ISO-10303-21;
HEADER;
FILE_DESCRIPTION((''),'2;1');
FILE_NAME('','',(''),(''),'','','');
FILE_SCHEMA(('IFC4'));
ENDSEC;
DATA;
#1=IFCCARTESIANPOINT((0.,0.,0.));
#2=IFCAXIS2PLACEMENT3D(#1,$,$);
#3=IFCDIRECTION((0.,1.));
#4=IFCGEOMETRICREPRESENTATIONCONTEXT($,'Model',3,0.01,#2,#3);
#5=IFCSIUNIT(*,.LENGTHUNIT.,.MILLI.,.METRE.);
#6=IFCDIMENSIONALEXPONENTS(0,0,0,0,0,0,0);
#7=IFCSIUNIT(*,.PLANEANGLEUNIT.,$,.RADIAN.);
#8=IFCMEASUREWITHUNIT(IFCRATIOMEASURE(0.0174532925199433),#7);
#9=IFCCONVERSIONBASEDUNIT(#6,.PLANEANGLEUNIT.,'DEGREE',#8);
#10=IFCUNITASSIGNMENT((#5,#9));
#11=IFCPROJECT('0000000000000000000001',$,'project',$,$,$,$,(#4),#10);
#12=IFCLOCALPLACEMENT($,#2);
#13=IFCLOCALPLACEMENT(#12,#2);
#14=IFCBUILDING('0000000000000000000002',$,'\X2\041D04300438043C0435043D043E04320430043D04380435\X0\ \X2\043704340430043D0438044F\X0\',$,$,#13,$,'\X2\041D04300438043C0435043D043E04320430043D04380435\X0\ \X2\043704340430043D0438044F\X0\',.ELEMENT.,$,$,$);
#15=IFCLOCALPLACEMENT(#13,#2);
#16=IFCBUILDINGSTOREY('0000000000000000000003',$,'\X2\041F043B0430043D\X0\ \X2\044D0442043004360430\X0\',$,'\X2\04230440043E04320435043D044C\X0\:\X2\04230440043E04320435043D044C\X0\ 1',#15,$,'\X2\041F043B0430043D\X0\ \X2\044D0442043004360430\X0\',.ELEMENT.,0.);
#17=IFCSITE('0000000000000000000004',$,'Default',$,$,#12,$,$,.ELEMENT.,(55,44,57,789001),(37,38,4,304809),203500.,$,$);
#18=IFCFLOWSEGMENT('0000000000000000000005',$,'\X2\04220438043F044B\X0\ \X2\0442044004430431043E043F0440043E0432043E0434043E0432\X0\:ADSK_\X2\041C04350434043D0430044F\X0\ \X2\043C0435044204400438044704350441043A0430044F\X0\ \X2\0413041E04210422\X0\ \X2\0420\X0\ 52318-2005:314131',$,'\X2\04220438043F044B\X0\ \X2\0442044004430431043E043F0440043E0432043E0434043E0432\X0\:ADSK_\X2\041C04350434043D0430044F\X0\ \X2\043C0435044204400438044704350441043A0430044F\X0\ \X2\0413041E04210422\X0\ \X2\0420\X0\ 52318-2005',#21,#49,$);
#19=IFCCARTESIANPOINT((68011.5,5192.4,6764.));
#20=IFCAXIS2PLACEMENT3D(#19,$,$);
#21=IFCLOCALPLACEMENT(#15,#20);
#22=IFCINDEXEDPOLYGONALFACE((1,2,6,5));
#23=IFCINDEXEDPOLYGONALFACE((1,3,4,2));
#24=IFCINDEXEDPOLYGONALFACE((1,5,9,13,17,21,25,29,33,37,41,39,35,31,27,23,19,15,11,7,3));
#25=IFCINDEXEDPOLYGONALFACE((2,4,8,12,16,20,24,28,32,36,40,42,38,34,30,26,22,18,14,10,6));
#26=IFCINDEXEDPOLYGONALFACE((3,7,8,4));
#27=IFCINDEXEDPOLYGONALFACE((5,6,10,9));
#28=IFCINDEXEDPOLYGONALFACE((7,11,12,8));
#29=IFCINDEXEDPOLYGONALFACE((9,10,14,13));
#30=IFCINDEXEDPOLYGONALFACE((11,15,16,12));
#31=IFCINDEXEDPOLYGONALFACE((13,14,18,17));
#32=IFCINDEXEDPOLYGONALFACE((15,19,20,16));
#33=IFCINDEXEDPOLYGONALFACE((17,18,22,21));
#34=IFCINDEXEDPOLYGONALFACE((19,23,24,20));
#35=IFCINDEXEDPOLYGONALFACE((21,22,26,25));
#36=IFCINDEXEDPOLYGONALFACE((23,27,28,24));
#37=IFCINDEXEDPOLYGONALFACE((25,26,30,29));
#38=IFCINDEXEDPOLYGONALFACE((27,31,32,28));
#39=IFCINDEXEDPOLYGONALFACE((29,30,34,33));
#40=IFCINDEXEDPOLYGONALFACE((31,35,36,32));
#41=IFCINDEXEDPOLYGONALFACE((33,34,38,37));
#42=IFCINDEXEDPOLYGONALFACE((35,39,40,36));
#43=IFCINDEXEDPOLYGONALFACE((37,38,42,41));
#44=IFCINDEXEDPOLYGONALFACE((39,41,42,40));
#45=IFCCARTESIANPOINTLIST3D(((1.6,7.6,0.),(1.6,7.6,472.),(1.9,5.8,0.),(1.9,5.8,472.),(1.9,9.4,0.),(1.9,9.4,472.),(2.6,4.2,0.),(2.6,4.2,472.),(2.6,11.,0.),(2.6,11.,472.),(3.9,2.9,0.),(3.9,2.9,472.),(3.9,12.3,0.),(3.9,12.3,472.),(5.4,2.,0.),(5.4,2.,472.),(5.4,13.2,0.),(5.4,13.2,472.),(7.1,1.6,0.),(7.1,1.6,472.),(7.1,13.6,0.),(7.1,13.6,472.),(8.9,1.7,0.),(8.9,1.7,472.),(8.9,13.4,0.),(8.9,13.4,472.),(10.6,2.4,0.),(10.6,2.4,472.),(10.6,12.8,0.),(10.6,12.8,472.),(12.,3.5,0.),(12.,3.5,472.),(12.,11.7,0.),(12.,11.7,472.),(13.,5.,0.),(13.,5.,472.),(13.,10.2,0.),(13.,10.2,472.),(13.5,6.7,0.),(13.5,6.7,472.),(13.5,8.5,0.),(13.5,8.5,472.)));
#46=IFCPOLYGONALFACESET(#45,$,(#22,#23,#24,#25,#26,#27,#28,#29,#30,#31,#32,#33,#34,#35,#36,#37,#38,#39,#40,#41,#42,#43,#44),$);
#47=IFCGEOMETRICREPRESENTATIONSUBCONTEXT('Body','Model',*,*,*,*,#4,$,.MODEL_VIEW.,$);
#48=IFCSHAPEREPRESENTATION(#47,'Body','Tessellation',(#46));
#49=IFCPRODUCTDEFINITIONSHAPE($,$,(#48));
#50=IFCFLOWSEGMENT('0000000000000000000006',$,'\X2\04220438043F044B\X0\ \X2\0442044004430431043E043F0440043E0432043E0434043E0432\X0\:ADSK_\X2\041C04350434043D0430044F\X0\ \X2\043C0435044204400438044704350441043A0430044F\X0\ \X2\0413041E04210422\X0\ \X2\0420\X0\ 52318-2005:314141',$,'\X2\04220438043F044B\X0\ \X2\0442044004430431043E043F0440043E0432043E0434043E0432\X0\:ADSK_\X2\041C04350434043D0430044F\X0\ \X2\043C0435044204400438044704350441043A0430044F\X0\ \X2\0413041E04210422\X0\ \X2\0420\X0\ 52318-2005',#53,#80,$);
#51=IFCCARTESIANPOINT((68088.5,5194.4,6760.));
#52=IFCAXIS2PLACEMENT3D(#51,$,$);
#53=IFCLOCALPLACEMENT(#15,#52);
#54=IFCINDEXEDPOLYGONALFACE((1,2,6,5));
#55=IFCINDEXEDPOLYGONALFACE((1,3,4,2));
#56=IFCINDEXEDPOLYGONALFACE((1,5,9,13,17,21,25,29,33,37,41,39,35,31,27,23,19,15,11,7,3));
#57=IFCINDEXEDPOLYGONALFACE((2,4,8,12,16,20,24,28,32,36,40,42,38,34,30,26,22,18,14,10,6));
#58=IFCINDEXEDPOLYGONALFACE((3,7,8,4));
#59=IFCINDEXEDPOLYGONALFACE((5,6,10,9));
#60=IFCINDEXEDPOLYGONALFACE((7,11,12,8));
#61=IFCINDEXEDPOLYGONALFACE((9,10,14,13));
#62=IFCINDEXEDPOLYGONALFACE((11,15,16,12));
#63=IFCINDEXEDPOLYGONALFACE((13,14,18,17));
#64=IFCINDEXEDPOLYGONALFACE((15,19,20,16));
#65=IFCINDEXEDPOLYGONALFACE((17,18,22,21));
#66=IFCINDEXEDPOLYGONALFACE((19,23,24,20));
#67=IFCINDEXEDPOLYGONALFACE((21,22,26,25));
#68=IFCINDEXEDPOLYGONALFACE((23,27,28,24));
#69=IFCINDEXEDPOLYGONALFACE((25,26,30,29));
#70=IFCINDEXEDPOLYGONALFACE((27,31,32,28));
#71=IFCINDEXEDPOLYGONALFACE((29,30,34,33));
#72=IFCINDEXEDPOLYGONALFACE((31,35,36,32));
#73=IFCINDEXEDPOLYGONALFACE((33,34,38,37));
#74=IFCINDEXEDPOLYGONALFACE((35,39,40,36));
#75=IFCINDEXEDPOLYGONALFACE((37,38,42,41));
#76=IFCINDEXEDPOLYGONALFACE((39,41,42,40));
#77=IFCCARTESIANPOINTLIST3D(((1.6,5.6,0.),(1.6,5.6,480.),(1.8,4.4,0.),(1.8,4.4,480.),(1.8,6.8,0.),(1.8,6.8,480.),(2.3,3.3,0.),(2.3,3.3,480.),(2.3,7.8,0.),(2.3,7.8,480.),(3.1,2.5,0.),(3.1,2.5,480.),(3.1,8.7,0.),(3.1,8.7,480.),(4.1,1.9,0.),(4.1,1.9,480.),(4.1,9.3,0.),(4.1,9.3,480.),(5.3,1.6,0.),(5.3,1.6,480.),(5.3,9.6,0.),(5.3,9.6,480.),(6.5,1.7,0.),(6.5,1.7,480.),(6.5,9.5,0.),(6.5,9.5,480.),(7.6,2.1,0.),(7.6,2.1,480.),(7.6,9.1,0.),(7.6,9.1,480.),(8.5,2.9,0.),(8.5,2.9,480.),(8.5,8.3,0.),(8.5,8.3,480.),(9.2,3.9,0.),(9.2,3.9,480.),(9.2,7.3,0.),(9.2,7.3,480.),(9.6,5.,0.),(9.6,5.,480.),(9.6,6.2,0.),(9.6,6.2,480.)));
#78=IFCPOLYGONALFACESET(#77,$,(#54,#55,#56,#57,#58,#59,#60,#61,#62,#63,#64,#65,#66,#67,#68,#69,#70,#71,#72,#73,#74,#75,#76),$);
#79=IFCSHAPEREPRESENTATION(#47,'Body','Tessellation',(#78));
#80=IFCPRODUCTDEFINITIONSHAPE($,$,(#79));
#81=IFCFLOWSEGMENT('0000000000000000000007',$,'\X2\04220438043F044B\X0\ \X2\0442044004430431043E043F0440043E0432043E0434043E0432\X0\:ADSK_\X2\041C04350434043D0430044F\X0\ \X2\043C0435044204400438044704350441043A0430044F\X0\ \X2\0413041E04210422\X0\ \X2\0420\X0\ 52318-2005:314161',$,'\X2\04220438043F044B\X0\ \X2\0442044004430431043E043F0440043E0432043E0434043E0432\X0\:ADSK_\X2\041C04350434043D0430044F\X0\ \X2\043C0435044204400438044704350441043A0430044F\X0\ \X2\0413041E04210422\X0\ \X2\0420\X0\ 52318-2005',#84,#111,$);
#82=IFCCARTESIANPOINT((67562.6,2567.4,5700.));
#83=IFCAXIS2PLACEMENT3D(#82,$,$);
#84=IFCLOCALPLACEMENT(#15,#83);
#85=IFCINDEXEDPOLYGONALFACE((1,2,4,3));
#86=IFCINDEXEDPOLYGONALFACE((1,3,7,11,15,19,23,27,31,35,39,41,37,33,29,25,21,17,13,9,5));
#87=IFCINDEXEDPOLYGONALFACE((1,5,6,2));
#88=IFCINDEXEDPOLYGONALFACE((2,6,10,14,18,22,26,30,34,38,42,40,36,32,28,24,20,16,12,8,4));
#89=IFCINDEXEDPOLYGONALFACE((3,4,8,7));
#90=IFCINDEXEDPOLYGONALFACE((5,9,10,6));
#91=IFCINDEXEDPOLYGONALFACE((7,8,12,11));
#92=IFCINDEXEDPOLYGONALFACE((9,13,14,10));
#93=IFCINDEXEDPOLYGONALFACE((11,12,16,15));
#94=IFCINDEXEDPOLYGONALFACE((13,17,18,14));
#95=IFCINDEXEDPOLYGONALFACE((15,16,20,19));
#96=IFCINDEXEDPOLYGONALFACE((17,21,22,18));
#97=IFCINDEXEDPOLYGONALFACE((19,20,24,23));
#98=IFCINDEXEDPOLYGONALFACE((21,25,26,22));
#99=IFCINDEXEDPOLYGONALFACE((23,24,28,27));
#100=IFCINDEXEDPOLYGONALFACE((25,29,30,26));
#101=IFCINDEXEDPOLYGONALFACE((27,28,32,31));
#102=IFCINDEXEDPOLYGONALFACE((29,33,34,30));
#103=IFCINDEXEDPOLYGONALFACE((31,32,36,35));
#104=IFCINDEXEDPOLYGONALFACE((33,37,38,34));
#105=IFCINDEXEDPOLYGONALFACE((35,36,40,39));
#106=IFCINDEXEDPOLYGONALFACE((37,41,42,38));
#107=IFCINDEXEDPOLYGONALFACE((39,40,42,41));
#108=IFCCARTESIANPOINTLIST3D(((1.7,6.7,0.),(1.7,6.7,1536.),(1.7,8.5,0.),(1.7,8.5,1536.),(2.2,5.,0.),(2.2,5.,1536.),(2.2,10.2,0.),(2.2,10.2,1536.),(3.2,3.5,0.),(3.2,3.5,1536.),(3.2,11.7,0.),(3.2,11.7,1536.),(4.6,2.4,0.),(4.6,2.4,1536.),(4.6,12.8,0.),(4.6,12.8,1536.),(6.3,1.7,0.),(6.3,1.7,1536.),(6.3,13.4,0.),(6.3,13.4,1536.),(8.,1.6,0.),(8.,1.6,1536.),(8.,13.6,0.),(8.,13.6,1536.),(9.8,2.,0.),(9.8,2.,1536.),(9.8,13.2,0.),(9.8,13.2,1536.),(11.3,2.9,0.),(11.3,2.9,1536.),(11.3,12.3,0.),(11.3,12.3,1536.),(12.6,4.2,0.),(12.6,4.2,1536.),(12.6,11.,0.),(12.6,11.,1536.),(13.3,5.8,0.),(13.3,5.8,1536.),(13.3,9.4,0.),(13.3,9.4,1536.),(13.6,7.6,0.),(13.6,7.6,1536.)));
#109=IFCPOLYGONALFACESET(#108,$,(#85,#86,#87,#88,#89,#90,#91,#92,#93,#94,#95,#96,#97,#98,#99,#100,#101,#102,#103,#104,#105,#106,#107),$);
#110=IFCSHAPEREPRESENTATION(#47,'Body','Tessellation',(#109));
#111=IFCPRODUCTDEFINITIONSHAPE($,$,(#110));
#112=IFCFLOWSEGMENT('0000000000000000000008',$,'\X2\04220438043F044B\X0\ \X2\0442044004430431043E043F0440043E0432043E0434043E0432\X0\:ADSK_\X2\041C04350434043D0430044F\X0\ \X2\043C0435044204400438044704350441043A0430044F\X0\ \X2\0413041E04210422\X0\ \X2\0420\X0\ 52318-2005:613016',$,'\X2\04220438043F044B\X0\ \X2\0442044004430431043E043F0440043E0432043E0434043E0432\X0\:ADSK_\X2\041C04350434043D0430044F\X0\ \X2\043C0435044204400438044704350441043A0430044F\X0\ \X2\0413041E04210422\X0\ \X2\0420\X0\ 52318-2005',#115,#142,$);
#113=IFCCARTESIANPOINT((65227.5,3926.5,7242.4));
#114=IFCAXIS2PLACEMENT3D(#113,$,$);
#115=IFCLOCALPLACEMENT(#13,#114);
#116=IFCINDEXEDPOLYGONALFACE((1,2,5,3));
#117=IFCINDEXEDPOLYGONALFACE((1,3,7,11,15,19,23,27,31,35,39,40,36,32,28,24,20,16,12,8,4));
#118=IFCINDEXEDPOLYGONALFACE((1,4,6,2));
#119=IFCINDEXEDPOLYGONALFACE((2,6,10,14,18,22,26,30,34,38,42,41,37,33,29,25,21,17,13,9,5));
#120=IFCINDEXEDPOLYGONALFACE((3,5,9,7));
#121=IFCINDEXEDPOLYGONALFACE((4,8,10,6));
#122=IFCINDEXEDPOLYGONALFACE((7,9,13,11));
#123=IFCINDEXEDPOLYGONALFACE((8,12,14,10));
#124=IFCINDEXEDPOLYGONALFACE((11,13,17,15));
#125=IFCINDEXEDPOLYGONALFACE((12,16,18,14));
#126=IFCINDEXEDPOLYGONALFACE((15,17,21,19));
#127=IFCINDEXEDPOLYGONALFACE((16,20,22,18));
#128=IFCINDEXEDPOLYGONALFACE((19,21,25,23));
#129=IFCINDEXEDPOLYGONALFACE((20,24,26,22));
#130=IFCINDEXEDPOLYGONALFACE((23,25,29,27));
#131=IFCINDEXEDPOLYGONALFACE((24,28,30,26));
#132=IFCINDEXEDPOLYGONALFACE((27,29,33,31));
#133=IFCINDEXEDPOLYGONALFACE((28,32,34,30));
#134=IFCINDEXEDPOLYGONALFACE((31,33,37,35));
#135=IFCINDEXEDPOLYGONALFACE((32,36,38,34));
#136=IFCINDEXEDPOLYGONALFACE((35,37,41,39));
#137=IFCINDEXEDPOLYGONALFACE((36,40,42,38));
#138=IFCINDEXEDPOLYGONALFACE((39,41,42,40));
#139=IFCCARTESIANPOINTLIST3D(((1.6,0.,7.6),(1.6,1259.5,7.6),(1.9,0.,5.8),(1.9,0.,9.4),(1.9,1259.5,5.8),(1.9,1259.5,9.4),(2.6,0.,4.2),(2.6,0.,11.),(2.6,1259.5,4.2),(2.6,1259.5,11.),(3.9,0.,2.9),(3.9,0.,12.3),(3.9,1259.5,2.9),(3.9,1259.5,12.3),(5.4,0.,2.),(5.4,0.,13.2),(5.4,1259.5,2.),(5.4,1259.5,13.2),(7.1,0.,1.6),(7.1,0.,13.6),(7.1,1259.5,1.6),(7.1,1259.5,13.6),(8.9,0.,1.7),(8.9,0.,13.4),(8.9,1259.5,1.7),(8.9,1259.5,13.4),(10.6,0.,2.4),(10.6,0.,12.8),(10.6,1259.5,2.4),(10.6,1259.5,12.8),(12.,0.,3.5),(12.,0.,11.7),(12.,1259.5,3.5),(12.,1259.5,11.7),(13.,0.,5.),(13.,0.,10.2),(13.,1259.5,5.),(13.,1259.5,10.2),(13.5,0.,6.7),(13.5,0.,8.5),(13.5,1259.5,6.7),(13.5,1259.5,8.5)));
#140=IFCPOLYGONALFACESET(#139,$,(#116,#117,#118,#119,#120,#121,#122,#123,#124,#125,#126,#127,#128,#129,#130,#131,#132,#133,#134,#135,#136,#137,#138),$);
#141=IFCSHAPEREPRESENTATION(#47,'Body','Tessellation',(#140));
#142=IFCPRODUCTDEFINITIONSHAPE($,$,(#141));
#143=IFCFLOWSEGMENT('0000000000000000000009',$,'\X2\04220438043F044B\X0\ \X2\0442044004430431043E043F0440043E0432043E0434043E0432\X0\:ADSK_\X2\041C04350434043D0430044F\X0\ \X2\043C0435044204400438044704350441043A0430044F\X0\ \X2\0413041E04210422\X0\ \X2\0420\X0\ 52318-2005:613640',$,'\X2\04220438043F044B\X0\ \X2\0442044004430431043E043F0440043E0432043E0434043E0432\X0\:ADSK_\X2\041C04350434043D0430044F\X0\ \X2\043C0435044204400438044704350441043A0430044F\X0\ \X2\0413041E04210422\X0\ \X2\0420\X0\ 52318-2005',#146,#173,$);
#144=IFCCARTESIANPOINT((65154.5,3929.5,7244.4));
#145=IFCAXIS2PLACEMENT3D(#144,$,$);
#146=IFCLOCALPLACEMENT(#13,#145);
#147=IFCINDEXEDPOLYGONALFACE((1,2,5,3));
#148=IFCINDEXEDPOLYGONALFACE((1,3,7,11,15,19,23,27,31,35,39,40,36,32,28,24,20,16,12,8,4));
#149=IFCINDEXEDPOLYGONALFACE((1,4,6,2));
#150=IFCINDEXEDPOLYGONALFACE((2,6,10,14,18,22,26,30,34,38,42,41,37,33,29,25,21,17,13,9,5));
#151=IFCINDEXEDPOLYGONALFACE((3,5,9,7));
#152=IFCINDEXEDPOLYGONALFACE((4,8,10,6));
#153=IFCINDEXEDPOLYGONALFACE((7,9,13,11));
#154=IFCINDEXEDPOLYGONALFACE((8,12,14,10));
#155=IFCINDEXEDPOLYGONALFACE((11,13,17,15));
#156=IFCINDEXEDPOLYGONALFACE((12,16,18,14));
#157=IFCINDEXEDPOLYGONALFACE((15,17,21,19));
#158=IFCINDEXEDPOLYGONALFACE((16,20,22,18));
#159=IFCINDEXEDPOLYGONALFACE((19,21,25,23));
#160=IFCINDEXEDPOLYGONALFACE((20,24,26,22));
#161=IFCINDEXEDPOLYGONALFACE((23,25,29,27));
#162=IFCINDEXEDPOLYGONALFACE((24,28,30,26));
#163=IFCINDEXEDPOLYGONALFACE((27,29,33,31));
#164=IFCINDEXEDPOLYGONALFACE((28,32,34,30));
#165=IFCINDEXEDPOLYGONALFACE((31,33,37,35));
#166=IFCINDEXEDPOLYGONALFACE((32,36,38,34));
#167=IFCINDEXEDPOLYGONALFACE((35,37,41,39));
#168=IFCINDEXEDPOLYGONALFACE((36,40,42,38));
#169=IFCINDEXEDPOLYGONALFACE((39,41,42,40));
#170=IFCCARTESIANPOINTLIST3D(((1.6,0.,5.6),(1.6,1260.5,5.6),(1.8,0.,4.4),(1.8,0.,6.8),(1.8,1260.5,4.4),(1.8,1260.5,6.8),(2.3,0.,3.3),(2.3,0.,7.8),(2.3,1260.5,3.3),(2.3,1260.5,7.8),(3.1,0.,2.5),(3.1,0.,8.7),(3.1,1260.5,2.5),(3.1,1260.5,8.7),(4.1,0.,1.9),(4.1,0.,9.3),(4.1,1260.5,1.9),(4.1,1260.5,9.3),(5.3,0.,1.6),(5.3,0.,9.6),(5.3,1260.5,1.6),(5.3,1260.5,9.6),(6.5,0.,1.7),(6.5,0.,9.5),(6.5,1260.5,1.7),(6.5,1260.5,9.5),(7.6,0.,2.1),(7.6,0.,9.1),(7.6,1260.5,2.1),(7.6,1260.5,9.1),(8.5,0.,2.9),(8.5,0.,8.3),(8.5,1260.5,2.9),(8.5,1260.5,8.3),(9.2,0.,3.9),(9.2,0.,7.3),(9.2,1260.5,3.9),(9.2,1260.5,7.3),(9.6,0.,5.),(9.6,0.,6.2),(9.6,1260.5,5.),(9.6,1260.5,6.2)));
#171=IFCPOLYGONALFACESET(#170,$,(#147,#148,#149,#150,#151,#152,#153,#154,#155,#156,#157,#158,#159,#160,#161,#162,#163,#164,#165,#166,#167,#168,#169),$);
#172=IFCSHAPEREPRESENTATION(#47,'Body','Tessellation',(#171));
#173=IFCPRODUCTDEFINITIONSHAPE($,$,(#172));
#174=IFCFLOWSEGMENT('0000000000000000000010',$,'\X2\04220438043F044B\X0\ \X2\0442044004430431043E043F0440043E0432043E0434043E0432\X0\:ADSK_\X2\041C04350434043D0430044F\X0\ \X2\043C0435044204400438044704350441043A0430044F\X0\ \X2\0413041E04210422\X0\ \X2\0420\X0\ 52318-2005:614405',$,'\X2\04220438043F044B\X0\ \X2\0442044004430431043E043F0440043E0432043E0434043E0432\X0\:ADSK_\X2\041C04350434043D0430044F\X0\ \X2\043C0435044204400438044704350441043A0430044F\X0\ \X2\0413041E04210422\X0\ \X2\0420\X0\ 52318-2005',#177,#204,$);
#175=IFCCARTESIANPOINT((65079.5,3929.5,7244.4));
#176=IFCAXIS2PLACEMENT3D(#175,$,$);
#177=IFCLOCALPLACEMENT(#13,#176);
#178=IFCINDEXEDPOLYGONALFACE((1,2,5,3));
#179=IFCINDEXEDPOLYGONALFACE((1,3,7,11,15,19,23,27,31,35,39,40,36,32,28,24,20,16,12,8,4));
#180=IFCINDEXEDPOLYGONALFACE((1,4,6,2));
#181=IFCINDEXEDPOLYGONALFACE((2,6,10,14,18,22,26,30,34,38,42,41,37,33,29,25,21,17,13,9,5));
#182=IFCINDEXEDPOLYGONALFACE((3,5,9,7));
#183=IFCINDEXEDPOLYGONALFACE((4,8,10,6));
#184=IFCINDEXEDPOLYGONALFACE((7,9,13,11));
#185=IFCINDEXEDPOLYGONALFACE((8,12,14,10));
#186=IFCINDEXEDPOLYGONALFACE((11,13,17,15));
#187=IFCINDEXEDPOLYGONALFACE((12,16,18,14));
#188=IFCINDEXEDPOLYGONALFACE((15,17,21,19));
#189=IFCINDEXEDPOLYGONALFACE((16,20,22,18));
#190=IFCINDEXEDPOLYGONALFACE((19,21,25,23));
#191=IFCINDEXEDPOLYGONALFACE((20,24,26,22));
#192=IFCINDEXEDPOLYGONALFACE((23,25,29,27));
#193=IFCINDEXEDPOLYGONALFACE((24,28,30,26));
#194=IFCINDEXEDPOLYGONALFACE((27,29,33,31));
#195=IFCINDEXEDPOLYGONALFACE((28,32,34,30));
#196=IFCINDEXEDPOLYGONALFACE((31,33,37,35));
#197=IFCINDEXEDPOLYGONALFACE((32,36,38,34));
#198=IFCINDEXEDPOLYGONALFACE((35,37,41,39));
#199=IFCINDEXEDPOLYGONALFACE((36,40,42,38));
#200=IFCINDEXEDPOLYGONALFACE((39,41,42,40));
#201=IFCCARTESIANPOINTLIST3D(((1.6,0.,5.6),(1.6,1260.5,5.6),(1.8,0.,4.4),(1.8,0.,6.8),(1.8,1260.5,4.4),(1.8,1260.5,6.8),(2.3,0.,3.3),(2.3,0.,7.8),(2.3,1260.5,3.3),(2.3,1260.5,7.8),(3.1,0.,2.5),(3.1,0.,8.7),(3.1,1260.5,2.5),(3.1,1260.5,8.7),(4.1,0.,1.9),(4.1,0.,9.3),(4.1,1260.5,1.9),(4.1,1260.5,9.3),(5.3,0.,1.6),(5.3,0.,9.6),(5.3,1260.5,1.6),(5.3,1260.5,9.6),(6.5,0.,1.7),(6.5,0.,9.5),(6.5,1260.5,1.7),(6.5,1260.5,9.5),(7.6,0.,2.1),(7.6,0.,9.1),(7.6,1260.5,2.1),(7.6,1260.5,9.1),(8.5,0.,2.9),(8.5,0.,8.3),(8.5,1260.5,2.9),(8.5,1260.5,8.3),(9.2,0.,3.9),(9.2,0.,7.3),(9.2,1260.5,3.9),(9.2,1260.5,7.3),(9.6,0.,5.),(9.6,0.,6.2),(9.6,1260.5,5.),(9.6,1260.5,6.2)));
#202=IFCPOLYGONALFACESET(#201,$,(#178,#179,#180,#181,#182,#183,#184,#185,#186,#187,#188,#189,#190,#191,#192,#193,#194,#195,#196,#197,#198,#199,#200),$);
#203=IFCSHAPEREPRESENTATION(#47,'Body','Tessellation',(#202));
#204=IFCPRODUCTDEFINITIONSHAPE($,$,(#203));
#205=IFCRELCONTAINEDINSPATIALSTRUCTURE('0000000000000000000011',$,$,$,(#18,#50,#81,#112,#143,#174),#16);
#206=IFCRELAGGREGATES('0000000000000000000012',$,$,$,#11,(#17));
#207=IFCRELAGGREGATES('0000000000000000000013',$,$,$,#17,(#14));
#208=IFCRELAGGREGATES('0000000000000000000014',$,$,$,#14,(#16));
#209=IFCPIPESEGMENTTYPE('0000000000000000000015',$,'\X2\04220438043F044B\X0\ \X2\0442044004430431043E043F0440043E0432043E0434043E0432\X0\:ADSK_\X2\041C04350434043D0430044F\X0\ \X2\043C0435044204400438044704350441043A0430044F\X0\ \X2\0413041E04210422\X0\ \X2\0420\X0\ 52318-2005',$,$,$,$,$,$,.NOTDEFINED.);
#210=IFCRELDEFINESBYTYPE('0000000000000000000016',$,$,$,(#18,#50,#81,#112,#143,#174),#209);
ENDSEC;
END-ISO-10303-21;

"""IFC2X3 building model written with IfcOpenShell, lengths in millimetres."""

from ifc_helpers import new_model, entity, si_unit, converted_unit, direction, frame, frame_2d, origin, origin_2d_with_axis, place, context, subcontext, project, spatial, circle, extrude, type_object, element, save


model = new_model("IFC2X3")

# Units and contexts
model_context = context("Model", 3, precision=0.01, world=origin(), true_north=direction((0.0, 1.0)))
body_context = subcontext(model_context, "Body", "Model", "MODEL_VIEW")
ifc_project = project(units=[si_unit("LENGTHUNIT", "METRE", prefix="MILLI"), converted_unit("PLANEANGLEUNIT", "DEGREE", entity("IfcRatioMeasure", 0.0174532925199433), si_unit("PLANEANGLEUNIT", "RADIAN"), dimensions=[0, 0, 0, 0, 0, 0, 0])], contexts=[model_context])

# Site, building, storey
site_placement = place(None, frame((0.0, 0.0, 0.0)))
site = spatial("IfcSite", under=ifc_project, at=site_placement, Name="Default", CompositionType="ELEMENT", RefLatitude=(55, 44, 57, 789001), RefLongitude=(37, 38, 4, 304809), RefElevation=203500.0)
building_placement = place(site_placement, origin())
building = spatial("IfcBuilding", under=site, at=building_placement, Name="Наименование здания", LongName="Наименование здания", CompositionType="ELEMENT")
storey_placement = place(building_placement, origin())
storey = spatial("IfcBuildingStorey", under=building, at=storey_placement, Name="План этажа", ObjectType="Уровень:Уровень 1", LongName="План этажа", CompositionType="ELEMENT", Elevation=0.0)

# Flow segments
pipe_segment_type = type_object("IfcPipeSegmentType", Name="Типы трубопроводов:ADSK_Медная метрическая ГОСТ Р 52318-2005", PredefinedType="NOTDEFINED")
flow_segment_1_placement = place(storey_placement, frame((68011.5, 5192.4, 6764.0)))
element("IfcFlowSegment", 1, at=flow_segment_1_placement, inside=storey, type_object=pipe_segment_type, Name="Типы трубопроводов:ADSK_Медная метрическая ГОСТ Р 52318-2005:314131", ObjectType="Типы трубопроводов:ADSK_Медная метрическая ГОСТ Р 52318-2005", context=body_context, shape_type="SweptSolid", body=[
    extrude(circle(Radius=6.0, at=origin_2d_with_axis()), frame((7.6, 7.6, 0.0), z_axis=(0.0, 0.0, 1.0), x_axis=(-1.0, 0.0, 0.0)), (0.0, 0.0, 1.0), 472.0),
])
flow_segment_2_placement = place(storey_placement, frame((68088.5, 5194.4, 6760.0)))
element("IfcFlowSegment", 2, at=flow_segment_2_placement, inside=storey, type_object=pipe_segment_type, Name="Типы трубопроводов:ADSK_Медная метрическая ГОСТ Р 52318-2005:314141", ObjectType="Типы трубопроводов:ADSK_Медная метрическая ГОСТ Р 52318-2005", context=body_context, shape_type="SweptSolid", body=[
    extrude(circle(Radius=4.0, at=origin_2d_with_axis()), frame((5.6, 5.6, 0.0), z_axis=(0.0, 0.0, 1.0), x_axis=(-1.0, 0.0, 0.0)), (0.0, 0.0, 1.0), 480.0),
])
flow_segment_3_placement = place(storey_placement, frame((67562.6, 2567.4, 5700.0)))
element("IfcFlowSegment", 3, at=flow_segment_3_placement, inside=storey, type_object=pipe_segment_type, Name="Типы трубопроводов:ADSK_Медная метрическая ГОСТ Р 52318-2005:314161", ObjectType="Типы трубопроводов:ADSK_Медная метрическая ГОСТ Р 52318-2005", context=body_context, shape_type="SweptSolid", body=[
    extrude(circle(Radius=6.0, at=origin_2d_with_axis()), frame((7.6, 7.6, 0.0)), (0.0, 0.0, 1.0), 1536.0),
])
flow_segment_4_placement = place(building_placement, frame((65227.5, 3926.5, 7242.4)))
element("IfcFlowSegment", 4, at=flow_segment_4_placement, inside=storey, type_object=pipe_segment_type, Name="Типы трубопроводов:ADSK_Медная метрическая ГОСТ Р 52318-2005:613016", ObjectType="Типы трубопроводов:ADSK_Медная метрическая ГОСТ Р 52318-2005", context=body_context, shape_type="SweptSolid", body=[
    extrude(circle(Radius=6.0, at=frame_2d((0.0, 0.0), x_axis=(1.0, 0.0))), frame((7.6, 0.0, 7.6), z_axis=(0.0, 1.0, 0.0), x_axis=(-1.0, 0.0, 0.0)), (0.0, 0.0, 1.0), 1259.5),
])
flow_segment_5_placement = place(building_placement, frame((65154.5, 3929.5, 7244.4)))
element("IfcFlowSegment", 5, at=flow_segment_5_placement, inside=storey, type_object=pipe_segment_type, Name="Типы трубопроводов:ADSK_Медная метрическая ГОСТ Р 52318-2005:613640", ObjectType="Типы трубопроводов:ADSK_Медная метрическая ГОСТ Р 52318-2005", context=body_context, shape_type="SweptSolid", body=[
    extrude(circle(Radius=4.0, at=frame_2d((0.0, 0.0), x_axis=(1.0, 0.0))), frame((5.6, 0.0, 5.6), z_axis=(0.0, 1.0, 0.0), x_axis=(-1.0, 0.0, 0.0)), (0.0, 0.0, 1.0), 1260.5),
])
flow_segment_6_placement = place(building_placement, frame((65079.5, 3929.5, 7244.4)))
element("IfcFlowSegment", 6, at=flow_segment_6_placement, inside=storey, type_object=pipe_segment_type, Name="Типы трубопроводов:ADSK_Медная метрическая ГОСТ Р 52318-2005:614405", ObjectType="Типы трубопроводов:ADSK_Медная метрическая ГОСТ Р 52318-2005", context=body_context, shape_type="SweptSolid", body=[
    extrude(circle(Radius=4.0, at=frame_2d((0.0, 0.0), x_axis=(1.0, 0.0))), frame((5.6, 0.0, 5.6), z_axis=(0.0, 1.0, 0.0), x_axis=(-1.0, 0.0, 0.0)), (0.0, 0.0, 1.0), 1260.5),
])

save(model, "model.ifc")
